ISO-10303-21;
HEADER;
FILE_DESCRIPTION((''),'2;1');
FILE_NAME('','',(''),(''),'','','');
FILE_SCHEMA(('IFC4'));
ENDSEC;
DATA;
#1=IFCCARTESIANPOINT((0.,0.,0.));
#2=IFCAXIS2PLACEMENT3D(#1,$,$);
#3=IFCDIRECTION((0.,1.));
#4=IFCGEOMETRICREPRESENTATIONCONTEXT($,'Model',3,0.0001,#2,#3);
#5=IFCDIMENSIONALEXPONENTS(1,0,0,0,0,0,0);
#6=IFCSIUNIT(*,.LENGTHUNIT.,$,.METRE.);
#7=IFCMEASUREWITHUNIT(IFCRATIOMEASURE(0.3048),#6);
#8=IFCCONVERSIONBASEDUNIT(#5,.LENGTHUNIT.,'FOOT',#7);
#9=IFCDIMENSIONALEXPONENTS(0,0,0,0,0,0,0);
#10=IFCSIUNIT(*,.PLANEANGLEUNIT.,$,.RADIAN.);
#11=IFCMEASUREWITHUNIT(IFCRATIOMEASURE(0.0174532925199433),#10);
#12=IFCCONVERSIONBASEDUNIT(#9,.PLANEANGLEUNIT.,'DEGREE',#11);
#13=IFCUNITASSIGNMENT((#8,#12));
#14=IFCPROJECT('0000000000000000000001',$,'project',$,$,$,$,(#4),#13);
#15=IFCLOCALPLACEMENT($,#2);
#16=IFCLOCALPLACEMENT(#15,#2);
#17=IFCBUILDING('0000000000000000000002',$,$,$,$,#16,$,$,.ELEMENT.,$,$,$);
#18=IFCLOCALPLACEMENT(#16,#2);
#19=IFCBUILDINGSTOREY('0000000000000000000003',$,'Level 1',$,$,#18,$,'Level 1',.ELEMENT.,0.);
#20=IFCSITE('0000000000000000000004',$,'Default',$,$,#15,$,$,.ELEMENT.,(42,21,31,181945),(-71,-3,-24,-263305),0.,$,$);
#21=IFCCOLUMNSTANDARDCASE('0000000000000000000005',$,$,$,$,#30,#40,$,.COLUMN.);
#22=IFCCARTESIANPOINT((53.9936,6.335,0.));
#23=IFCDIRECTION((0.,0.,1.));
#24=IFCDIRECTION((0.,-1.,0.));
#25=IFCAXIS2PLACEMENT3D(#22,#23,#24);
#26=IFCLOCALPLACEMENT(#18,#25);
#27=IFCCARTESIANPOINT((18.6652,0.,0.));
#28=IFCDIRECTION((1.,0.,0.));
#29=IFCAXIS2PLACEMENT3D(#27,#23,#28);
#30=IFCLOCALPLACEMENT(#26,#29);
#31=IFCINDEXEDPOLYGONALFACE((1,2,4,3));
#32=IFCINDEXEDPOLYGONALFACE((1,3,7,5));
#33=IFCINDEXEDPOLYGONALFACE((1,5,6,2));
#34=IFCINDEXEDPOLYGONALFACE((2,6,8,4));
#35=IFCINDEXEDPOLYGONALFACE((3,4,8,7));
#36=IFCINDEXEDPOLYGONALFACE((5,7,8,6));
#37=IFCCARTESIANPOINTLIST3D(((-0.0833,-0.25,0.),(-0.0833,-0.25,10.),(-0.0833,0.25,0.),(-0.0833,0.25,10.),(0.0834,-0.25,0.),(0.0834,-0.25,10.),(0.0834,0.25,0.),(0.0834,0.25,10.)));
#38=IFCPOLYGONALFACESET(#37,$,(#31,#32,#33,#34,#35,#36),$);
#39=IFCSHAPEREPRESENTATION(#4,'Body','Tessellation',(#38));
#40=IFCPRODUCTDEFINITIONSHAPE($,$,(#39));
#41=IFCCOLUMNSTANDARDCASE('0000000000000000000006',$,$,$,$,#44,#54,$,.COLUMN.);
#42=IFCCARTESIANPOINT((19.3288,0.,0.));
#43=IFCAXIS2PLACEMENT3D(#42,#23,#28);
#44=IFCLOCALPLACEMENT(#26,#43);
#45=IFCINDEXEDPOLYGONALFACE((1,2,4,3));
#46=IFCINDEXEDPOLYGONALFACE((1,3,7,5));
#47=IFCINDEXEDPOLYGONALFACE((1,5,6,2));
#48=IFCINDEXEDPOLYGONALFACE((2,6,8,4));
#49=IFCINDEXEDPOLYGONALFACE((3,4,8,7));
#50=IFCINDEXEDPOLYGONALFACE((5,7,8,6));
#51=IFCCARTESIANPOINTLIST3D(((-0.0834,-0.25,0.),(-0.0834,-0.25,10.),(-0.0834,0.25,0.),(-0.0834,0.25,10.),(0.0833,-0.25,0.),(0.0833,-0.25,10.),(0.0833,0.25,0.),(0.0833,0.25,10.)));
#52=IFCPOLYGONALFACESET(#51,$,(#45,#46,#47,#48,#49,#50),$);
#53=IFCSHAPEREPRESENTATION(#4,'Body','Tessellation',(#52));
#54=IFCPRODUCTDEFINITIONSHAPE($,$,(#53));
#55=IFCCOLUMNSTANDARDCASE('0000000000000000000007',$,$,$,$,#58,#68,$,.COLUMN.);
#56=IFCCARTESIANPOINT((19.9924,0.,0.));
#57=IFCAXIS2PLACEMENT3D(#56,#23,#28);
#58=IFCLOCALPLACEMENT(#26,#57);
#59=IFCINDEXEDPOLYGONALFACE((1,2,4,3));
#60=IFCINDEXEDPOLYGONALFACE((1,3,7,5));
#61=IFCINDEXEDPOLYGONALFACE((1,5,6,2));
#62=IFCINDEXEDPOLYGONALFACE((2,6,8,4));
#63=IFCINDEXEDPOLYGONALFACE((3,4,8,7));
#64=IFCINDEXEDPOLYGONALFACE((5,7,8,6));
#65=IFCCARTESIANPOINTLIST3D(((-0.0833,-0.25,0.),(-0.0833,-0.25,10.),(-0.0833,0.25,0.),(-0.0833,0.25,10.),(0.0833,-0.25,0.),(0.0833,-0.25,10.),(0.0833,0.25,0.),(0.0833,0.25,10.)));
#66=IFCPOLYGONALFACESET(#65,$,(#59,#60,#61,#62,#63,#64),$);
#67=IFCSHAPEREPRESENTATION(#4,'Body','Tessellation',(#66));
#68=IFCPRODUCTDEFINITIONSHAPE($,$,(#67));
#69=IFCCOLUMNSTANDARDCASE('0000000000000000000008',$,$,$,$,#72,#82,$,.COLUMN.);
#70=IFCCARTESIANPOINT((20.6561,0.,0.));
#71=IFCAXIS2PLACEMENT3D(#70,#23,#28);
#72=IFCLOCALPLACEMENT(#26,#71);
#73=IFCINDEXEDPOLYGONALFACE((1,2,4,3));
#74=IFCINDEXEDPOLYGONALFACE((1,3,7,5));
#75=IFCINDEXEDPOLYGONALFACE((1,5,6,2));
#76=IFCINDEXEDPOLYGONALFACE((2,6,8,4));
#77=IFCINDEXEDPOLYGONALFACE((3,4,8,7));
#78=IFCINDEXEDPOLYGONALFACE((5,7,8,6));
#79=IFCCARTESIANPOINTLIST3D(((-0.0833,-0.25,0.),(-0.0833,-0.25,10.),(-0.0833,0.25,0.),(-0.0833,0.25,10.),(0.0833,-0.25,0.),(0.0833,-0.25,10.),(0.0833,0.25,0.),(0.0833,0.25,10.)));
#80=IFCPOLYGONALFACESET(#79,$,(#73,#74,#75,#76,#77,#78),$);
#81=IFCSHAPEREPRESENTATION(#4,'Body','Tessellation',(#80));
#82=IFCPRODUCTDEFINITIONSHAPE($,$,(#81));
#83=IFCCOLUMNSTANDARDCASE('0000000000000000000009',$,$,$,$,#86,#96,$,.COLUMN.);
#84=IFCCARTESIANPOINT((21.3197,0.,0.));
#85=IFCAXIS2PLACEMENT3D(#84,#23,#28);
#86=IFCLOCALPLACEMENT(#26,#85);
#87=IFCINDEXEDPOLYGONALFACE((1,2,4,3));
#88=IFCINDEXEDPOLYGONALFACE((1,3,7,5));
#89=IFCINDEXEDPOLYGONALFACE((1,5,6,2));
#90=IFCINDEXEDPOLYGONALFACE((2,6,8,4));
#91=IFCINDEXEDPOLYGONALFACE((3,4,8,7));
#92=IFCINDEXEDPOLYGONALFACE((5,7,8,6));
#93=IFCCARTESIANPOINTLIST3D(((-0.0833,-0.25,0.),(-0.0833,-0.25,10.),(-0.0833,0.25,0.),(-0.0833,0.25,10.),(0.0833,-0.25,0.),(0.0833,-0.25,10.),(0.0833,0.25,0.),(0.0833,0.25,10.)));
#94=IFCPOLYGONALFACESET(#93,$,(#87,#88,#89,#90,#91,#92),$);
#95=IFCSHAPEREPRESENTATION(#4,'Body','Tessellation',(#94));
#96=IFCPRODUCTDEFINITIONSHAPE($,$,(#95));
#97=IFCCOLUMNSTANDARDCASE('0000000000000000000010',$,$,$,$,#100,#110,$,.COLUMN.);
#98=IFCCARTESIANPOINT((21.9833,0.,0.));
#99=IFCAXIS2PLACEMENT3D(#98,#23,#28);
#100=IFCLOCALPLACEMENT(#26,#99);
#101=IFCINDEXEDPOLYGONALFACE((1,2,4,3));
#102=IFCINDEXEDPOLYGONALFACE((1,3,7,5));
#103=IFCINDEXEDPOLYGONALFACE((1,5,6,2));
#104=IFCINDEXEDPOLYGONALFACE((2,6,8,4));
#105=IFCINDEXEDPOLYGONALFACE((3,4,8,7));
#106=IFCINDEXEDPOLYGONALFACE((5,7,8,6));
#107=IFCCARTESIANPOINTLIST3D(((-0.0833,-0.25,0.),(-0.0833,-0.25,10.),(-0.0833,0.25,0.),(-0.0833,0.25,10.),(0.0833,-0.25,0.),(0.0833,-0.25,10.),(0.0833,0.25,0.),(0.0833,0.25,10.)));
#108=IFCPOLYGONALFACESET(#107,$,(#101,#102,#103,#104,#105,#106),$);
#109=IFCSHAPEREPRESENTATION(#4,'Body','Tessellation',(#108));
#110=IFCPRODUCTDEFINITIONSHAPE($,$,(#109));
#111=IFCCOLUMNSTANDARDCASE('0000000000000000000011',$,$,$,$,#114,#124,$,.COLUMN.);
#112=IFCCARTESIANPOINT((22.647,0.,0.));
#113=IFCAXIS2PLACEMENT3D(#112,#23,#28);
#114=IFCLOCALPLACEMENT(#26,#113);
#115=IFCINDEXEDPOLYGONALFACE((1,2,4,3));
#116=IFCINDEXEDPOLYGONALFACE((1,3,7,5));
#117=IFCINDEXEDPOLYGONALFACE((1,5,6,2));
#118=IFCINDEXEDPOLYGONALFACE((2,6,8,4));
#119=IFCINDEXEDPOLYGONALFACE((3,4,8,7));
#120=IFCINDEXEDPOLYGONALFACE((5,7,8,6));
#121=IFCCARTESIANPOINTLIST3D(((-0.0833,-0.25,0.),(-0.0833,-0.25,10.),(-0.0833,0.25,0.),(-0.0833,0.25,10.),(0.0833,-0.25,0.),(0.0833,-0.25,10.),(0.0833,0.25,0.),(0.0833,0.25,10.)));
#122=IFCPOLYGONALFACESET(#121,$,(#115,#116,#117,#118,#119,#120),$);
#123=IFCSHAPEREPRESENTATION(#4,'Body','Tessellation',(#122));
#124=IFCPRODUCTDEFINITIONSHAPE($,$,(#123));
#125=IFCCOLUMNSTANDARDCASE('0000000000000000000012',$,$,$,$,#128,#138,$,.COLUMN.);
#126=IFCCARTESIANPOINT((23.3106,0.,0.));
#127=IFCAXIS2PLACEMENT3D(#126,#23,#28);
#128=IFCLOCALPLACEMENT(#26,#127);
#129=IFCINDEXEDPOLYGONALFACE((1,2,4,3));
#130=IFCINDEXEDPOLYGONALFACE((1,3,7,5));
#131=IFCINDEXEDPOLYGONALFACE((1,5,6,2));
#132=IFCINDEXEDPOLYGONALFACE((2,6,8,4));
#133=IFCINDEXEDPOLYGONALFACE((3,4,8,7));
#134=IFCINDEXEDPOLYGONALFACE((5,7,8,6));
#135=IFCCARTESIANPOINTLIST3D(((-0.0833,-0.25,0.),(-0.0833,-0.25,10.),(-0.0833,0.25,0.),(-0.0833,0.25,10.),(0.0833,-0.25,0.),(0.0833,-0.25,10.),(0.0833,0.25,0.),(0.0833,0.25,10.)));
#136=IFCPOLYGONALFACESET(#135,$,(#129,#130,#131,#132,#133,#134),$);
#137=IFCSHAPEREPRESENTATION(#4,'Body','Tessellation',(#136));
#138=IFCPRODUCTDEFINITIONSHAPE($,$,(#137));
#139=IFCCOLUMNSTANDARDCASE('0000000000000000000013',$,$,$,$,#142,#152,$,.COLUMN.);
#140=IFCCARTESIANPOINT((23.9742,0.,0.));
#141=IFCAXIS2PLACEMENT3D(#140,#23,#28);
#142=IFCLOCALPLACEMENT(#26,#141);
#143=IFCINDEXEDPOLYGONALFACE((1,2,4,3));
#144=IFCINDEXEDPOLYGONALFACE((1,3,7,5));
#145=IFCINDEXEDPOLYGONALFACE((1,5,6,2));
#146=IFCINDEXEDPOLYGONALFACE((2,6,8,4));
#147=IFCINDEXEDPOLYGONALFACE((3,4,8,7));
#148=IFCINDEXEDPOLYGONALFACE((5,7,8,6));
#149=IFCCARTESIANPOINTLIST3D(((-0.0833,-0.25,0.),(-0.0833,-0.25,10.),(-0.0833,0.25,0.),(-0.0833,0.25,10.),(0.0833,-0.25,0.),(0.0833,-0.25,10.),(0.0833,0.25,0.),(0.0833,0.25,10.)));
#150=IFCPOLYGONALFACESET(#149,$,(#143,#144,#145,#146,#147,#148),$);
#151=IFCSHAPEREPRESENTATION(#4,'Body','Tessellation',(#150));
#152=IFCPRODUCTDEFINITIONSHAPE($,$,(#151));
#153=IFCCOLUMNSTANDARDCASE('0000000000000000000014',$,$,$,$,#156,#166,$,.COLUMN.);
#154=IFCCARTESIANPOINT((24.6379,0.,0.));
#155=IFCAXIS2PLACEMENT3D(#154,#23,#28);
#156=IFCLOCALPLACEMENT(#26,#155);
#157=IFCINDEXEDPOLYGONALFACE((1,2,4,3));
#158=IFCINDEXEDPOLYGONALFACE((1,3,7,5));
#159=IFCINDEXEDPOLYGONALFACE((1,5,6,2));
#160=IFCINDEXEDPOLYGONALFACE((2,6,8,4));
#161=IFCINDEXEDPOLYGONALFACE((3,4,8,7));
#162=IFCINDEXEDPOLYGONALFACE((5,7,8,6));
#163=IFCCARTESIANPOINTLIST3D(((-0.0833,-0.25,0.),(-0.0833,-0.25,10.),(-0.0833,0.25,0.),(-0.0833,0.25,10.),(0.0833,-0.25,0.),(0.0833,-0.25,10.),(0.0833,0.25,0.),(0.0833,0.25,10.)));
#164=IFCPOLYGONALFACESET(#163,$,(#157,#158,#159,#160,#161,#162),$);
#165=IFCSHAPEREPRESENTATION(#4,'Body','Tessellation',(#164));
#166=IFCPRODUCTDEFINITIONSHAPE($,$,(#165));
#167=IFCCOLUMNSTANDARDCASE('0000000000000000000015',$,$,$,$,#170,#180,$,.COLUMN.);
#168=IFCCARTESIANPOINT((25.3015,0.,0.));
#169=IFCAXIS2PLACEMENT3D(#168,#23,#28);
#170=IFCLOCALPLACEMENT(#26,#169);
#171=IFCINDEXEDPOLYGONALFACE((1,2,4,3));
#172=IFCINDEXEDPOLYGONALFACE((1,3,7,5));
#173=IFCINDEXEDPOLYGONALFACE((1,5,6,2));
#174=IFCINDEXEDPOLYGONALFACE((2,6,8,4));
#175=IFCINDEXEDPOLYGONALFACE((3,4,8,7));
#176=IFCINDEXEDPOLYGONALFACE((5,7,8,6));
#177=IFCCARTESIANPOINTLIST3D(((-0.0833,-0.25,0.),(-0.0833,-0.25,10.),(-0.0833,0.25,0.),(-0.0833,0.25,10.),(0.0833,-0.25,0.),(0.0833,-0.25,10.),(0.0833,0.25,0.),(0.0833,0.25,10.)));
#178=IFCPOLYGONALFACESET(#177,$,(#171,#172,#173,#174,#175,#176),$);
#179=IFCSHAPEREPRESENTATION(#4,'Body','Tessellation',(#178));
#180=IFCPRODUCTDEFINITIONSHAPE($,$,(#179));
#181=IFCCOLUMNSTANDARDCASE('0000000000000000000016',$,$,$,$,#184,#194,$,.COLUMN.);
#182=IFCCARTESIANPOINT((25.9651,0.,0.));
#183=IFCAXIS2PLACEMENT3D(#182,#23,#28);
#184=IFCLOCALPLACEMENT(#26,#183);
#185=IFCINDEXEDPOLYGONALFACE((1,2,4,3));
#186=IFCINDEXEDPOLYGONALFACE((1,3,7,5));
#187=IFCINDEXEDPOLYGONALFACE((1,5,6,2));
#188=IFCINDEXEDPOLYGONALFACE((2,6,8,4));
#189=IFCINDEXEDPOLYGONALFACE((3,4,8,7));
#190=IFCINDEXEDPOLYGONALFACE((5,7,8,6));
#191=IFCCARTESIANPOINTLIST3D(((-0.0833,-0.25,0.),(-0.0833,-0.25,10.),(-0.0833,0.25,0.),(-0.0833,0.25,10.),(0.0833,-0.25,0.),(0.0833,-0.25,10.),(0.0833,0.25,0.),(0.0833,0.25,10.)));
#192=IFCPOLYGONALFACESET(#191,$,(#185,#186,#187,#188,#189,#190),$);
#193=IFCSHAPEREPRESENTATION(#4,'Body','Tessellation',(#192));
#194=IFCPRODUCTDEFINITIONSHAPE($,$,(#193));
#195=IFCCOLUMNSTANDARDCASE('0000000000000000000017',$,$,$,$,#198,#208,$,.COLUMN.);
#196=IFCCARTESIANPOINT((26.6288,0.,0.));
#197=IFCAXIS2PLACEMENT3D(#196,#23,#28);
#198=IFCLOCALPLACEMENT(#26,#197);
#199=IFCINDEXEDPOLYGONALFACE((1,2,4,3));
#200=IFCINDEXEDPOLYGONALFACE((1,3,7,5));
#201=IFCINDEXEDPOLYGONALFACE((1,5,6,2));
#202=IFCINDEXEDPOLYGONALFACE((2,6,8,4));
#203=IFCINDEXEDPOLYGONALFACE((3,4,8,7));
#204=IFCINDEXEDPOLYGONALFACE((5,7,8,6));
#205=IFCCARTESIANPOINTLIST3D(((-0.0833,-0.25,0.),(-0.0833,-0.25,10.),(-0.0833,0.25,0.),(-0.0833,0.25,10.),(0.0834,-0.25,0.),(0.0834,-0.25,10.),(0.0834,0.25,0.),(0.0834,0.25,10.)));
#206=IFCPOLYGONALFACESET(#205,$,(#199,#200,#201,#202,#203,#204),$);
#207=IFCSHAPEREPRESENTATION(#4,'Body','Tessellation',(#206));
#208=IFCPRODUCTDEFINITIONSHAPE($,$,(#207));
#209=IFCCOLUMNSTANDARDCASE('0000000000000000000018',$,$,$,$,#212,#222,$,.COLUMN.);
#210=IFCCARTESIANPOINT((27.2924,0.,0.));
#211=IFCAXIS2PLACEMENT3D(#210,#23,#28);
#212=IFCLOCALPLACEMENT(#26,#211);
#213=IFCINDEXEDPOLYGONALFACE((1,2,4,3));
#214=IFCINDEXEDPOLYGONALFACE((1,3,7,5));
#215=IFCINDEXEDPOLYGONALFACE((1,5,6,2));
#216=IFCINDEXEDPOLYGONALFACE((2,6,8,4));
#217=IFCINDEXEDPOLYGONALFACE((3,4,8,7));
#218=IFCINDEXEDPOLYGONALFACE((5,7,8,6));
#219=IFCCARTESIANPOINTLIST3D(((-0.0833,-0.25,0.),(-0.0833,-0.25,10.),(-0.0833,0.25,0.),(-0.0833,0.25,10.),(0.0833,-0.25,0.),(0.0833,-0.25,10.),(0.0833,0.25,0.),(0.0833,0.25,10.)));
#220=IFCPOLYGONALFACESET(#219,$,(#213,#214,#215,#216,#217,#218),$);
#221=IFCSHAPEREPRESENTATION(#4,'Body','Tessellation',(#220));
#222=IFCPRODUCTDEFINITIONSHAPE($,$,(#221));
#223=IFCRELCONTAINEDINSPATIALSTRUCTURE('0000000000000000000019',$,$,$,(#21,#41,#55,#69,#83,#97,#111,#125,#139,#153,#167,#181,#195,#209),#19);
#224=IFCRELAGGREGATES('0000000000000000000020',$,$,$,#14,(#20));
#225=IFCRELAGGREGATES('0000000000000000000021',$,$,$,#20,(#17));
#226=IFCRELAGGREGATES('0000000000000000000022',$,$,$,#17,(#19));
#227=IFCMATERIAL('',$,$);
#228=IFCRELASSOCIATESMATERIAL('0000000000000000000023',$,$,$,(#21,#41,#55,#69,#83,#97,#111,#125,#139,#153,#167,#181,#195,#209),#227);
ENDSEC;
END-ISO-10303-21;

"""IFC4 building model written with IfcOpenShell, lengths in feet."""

from ifc_helpers import new_model, entity, si_unit, converted_unit, direction, frame, origin, place, context, project, spatial, rectangle, extrude, material, element, save


model = new_model("IFC4")

# Units and contexts
model_context = context("Model", 3, precision=0.0001, world=origin(), true_north=direction((0.0, 1.0)))
ifc_project = project(units=[converted_unit("LENGTHUNIT", "FOOT", entity("IfcRatioMeasure", 0.3048), si_unit("LENGTHUNIT", "METRE"), dimensions=[1, 0, 0, 0, 0, 0, 0]), converted_unit("PLANEANGLEUNIT", "DEGREE", entity("IfcRatioMeasure", 0.0174532925199433), si_unit("PLANEANGLEUNIT", "RADIAN"), dimensions=[0, 0, 0, 0, 0, 0, 0])], contexts=[model_context])

# Site, building, storey
site_placement = place(None, origin())
site = spatial("IfcSite", under=ifc_project, at=site_placement, Name="Default", CompositionType="ELEMENT", RefLatitude=(42, 21, 31, 181945), RefLongitude=(-71, -3, -24, -263305), RefElevation=0.0)
building_placement = place(site_placement, origin())
building = spatial("IfcBuilding", under=site, at=building_placement, CompositionType="ELEMENT")
storey_placement = place(building_placement, origin())
storey = spatial("IfcBuildingStorey", under=building, at=storey_placement, Name="Level 1", LongName="Level 1", CompositionType="ELEMENT", Elevation=0.0)

# Columns
ifc_material_1 = material(Name="")
placement = place(storey_placement, frame((53.9936, 6.335, 0.0), z_axis=(0.0, 0.0, 1.0), x_axis=(0.0, -1.0, 0.0)))
for number, where, z_axis, x_axis in (
    (1, (18.6652, 0.0, 0.0), (0.0, 0.0, 1.0), (1.0, 0.0, 0.0)),
    (2, (19.3288, 0.0, 0.0), (0.0, 0.0, 1.0), (1.0, 0.0, 0.0)),
    (3, (19.9924, 0.0, 0.0), (0.0, 0.0, 1.0), (1.0, 0.0, 0.0)),
    (4, (20.6561, 0.0, 0.0), (0.0, 0.0, 1.0), (1.0, 0.0, 0.0)),
    (5, (21.3197, 0.0, 0.0), (0.0, 0.0, 1.0), (1.0, 0.0, 0.0)),
    (6, (21.9833, 0.0, 0.0), (0.0, 0.0, 1.0), (1.0, 0.0, 0.0)),
    (7, (22.647, 0.0, 0.0), (0.0, 0.0, 1.0), (1.0, 0.0, 0.0)),
    (8, (23.3106, 0.0, 0.0), (0.0, 0.0, 1.0), (1.0, 0.0, 0.0)),
    (9, (23.9742, 0.0, 0.0), (0.0, 0.0, 1.0), (1.0, 0.0, 0.0)),
    (10, (24.6379, 0.0, 0.0), (0.0, 0.0, 1.0), (1.0, 0.0, 0.0)),
    (11, (25.3015, 0.0, 0.0), (0.0, 0.0, 1.0), (1.0, 0.0, 0.0)),
    (12, (25.9651, 0.0, 0.0), (0.0, 0.0, 1.0), (1.0, 0.0, 0.0)),
    (13, (26.6288, 0.0, 0.0), (0.0, 0.0, 1.0), (1.0, 0.0, 0.0)),
    (14, (27.2924, 0.0, 0.0), (0.0, 0.0, 1.0), (1.0, 0.0, 0.0)),
):
    element("IfcColumnStandardCase", number, at=place(placement, frame(where, z_axis=z_axis, x_axis=x_axis)), inside=storey, material=ifc_material_1, PredefinedType="COLUMN", context=model_context, shape_type="SweptSolid", body=[
        extrude(rectangle(XDim=0.1667, YDim=0.5), origin(), (0.0, 0.0, 1.0), 10.0),
    ])

save(model, "model.ifc")
